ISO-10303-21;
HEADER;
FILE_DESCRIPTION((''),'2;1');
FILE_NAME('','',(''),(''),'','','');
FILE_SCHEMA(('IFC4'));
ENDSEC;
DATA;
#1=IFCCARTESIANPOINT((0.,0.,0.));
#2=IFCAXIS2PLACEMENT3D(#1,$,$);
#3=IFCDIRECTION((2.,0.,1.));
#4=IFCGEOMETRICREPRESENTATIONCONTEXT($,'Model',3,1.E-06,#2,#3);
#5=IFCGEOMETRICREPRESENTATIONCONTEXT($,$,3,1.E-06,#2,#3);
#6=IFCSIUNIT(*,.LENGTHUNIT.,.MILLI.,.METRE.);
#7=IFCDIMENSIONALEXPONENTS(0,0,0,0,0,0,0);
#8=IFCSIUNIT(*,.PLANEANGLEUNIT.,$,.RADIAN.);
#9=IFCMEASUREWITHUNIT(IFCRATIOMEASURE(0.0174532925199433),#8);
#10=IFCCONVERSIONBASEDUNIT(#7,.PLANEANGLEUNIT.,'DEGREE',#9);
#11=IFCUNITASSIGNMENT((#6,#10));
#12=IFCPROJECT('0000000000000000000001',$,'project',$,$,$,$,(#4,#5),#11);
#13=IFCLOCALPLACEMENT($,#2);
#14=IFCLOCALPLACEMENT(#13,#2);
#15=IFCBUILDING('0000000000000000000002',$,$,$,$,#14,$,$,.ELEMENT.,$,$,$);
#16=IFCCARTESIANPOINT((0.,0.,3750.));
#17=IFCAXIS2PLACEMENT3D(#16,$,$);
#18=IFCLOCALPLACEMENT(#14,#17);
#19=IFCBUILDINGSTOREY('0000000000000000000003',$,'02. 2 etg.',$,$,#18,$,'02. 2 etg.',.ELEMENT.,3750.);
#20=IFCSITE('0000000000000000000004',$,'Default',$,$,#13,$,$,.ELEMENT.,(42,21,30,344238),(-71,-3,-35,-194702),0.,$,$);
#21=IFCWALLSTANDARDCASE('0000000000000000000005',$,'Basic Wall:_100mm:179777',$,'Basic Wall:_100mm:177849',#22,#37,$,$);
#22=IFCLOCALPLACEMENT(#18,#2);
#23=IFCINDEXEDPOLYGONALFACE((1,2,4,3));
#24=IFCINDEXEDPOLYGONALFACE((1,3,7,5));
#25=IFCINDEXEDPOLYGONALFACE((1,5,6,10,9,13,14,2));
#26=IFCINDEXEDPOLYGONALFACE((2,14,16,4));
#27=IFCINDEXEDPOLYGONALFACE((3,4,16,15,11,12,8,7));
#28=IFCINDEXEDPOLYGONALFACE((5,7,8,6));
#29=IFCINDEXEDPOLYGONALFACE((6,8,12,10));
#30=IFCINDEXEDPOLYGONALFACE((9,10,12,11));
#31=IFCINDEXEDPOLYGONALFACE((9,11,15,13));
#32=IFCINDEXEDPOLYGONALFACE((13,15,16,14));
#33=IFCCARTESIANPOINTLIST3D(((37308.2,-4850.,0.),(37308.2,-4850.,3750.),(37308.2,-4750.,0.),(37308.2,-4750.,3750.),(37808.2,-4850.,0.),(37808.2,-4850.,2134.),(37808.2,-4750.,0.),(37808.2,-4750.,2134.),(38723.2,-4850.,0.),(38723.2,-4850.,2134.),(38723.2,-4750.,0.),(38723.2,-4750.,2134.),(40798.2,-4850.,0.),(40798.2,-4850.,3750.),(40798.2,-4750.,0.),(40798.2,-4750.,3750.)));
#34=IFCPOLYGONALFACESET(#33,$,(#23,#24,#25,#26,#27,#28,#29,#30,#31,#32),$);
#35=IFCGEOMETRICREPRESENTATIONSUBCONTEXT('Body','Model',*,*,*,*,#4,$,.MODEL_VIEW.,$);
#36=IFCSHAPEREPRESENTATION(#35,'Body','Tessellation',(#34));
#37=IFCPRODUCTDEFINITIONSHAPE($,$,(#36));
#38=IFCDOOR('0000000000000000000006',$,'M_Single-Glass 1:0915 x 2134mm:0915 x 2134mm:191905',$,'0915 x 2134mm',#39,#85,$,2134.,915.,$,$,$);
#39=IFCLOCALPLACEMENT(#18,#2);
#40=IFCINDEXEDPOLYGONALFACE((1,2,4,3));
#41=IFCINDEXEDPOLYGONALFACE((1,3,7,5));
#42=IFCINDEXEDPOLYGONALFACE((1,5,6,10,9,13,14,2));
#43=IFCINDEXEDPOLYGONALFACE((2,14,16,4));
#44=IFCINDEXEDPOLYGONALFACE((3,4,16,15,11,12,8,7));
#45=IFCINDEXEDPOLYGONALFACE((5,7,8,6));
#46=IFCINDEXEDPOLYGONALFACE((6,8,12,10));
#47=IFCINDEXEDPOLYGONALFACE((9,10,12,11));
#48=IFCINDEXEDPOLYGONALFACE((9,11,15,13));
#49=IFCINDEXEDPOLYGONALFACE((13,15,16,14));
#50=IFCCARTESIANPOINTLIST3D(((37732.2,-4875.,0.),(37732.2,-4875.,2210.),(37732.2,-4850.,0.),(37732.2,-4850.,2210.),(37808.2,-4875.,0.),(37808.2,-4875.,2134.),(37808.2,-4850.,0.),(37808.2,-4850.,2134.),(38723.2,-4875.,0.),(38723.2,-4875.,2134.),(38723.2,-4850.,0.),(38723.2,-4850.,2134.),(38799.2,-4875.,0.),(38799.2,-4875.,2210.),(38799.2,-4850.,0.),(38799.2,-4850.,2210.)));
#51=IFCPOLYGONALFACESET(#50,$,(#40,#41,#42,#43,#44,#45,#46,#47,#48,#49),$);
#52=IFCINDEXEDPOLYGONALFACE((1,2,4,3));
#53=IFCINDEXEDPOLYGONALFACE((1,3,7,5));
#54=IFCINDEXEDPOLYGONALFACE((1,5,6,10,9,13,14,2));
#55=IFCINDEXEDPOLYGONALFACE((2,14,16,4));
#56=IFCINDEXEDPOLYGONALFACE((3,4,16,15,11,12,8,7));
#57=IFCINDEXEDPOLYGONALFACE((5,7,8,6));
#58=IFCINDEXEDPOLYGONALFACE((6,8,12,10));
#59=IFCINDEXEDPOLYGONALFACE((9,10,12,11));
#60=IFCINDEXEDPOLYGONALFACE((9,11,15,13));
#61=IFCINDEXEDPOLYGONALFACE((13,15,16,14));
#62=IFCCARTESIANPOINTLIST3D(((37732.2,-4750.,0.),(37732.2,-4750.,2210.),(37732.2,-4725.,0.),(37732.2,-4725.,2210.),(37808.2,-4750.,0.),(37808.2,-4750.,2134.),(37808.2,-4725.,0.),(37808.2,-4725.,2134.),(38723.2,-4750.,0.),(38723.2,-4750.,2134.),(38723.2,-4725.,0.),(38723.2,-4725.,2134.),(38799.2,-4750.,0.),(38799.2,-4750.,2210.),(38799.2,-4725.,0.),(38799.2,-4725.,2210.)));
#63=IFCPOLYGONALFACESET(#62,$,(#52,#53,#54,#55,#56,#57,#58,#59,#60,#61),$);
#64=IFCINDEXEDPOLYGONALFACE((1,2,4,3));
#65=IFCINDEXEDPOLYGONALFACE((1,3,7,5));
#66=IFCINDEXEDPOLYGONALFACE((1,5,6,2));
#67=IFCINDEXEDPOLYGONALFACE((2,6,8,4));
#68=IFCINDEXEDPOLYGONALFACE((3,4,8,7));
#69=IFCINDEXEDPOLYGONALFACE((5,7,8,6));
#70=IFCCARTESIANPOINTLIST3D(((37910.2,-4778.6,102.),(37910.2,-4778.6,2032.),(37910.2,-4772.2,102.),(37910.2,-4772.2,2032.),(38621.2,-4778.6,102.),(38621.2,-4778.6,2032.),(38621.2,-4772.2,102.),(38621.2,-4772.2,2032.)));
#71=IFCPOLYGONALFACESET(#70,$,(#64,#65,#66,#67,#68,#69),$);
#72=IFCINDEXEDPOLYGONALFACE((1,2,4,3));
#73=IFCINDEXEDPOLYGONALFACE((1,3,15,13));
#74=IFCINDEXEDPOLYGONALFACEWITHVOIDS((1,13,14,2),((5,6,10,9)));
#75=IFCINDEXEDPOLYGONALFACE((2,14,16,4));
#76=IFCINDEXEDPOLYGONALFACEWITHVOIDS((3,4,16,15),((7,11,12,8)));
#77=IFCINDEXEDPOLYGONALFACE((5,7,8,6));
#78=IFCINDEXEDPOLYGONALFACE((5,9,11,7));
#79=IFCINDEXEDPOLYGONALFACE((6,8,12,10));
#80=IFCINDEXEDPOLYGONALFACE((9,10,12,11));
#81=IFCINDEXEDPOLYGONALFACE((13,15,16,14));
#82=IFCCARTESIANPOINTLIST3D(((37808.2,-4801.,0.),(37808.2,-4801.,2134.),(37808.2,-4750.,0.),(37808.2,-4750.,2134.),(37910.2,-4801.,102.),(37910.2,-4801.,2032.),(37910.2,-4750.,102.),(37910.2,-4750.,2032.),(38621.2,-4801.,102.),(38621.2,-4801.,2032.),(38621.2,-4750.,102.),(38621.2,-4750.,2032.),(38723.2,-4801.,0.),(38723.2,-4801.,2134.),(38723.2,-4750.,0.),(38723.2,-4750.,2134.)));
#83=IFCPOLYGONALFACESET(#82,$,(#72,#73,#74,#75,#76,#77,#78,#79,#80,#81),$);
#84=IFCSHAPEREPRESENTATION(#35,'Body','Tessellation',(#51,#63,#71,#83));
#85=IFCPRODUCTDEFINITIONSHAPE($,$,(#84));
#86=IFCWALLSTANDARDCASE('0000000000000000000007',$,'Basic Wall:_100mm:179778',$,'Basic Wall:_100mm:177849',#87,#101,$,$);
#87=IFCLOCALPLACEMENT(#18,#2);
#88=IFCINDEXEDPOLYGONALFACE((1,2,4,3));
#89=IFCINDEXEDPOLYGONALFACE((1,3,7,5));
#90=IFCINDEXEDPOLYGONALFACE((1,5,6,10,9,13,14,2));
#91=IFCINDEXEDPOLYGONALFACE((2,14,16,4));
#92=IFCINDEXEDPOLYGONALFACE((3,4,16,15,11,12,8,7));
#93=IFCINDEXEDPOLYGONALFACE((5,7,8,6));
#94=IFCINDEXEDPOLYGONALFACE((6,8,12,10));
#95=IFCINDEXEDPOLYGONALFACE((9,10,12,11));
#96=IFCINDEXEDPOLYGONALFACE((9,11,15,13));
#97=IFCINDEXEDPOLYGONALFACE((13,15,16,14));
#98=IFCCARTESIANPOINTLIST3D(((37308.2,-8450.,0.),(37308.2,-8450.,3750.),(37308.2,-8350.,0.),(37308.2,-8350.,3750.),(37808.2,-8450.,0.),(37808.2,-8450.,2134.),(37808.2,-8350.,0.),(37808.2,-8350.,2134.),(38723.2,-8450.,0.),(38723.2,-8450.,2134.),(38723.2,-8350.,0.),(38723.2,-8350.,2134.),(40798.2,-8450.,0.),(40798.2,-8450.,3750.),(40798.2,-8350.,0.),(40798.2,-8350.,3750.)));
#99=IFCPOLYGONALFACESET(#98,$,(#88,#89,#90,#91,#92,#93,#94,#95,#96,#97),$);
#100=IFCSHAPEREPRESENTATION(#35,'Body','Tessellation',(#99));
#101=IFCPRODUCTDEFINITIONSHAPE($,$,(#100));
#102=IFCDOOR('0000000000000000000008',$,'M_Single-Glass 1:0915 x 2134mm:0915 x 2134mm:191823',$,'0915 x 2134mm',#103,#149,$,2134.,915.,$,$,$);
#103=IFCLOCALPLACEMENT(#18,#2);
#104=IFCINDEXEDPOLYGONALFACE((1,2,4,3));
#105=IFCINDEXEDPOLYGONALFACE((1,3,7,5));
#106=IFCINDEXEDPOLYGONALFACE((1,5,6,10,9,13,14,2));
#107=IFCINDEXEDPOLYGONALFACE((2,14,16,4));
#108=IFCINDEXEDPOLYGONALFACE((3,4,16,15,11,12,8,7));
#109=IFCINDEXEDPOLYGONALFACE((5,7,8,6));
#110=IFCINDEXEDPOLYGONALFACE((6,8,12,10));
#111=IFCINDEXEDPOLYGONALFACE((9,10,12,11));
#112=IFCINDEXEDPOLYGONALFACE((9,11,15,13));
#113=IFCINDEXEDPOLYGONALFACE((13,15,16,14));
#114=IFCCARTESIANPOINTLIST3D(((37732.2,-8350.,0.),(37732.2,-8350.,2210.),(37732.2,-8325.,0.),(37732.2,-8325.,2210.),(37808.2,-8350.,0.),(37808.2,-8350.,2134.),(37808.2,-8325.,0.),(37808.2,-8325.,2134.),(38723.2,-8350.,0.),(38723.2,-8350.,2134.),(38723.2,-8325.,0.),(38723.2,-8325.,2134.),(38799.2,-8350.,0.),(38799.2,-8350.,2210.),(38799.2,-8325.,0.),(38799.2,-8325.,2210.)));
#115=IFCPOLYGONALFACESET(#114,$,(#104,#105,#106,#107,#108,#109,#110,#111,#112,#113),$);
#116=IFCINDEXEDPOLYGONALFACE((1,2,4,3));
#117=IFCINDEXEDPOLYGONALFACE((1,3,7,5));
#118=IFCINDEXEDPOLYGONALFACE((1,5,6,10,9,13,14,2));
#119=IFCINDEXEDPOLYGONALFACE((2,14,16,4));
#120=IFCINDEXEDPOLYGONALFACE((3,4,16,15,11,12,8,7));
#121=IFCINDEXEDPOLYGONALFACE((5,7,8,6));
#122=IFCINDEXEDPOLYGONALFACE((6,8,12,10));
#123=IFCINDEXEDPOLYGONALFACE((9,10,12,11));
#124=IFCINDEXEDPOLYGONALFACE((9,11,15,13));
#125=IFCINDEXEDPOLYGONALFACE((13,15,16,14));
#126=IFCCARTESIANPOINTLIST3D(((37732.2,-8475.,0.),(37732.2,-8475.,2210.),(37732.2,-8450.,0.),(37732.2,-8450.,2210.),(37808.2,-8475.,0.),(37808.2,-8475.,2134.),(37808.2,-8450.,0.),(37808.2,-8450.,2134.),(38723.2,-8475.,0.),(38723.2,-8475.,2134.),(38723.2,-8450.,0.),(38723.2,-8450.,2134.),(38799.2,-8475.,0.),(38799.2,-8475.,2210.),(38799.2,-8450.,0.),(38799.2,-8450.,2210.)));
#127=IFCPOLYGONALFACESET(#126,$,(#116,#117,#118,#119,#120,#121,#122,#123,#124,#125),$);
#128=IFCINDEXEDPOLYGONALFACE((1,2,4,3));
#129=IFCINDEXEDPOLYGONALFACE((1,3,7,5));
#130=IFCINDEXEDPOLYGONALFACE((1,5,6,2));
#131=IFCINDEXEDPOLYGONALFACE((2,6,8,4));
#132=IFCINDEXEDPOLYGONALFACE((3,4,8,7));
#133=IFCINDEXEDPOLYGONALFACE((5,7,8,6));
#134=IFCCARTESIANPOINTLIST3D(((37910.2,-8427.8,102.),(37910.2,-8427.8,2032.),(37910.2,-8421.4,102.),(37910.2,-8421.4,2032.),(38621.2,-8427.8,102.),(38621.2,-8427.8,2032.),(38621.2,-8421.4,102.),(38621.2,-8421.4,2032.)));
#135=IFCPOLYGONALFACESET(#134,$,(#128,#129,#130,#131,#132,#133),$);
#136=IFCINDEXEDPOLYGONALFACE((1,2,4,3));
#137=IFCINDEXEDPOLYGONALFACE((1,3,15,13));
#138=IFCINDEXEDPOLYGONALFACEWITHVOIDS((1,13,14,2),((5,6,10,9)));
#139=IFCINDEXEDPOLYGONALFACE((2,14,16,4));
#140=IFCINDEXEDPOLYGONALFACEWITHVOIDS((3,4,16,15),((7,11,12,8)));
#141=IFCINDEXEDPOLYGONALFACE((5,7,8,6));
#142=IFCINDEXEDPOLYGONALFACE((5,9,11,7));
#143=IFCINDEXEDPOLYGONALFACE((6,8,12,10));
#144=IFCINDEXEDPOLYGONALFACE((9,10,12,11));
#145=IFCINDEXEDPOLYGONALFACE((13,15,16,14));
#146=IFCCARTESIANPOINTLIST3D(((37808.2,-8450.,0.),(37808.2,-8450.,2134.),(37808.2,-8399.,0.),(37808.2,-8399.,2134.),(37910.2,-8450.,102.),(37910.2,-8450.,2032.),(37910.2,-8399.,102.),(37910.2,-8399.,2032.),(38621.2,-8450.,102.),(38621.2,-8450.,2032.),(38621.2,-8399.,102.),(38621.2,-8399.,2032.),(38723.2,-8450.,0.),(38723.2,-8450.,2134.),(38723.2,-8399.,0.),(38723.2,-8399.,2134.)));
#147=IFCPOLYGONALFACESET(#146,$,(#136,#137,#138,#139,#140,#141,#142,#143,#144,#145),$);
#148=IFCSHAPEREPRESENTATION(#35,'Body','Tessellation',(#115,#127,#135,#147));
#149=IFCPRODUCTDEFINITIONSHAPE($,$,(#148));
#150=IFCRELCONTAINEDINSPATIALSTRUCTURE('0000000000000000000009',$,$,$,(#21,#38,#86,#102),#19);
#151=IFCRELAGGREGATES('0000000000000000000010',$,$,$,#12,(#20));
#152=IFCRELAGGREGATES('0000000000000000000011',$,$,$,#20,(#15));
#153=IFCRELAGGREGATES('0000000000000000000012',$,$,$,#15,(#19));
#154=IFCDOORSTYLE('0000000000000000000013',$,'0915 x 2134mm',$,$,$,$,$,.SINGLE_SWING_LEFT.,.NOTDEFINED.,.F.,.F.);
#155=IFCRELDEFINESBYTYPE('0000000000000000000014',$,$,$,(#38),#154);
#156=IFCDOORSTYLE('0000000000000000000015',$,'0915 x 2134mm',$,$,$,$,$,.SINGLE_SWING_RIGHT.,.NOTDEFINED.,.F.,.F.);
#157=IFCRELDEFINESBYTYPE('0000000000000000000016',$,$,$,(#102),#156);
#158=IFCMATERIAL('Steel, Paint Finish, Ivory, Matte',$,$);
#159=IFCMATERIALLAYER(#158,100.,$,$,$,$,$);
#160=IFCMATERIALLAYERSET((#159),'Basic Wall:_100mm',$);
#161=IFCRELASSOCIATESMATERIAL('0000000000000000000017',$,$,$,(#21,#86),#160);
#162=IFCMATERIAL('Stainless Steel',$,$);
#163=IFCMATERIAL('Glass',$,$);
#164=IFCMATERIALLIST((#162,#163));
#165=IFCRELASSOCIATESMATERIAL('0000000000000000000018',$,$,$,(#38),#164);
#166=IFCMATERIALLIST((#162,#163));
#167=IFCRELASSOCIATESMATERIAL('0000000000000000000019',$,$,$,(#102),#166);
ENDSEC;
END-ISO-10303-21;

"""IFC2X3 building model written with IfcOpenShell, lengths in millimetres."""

from ifc_helpers import new_model, entity, si_unit, converted_unit, direction, frame, frame_2d, origin, origin_2d_with_axis, place, context, subcontext, project, spatial, polyline, rectangle, outline, extrude, source, transform, mapped, material, material_list, layer, layer_set, layer_usage, type_object, type_shapes, element, fill, save


model = new_model("IFC2X3")

# Units and contexts
model_context = context("Model", 3, precision=1e-06, world=origin(), true_north=direction((2.0, 0.0, 1.0)))
context_of_model = context(None, 3, precision=1e-06, world=origin(), true_north=direction((2.0, 0.0, 1.0)))
body_context = subcontext(model_context, "Body", "Model", "MODEL_VIEW")
ifc_project = project(units=[si_unit("LENGTHUNIT", "METRE", prefix="MILLI"), converted_unit("PLANEANGLEUNIT", "DEGREE", entity("IfcRatioMeasure", 0.0174532925199433), si_unit("PLANEANGLEUNIT", "RADIAN"), dimensions=[0, 0, 0, 0, 0, 0, 0])], contexts=[model_context, context_of_model])

# Site, building, storey
site_placement = place(None, origin())
site = spatial("IfcSite", under=ifc_project, at=site_placement, Name="Default", CompositionType="ELEMENT", RefLatitude=(42, 21, 30, 344238), RefLongitude=(-71, -3, -35, -194702), RefElevation=0.0)
building_placement = place(site_placement, origin())
building = spatial("IfcBuilding", under=site, at=building_placement, CompositionType="ELEMENT")
storey_placement = place(building_placement, frame((0.0, 0.0, 3750.0)))
storey = spatial("IfcBuildingStorey", under=building, at=storey_placement, Name="02. 2 etg.", LongName="02. 2 etg.", CompositionType="ELEMENT", Elevation=3750.0)

# Shared definitions
ifc_material_1 = material(Name="Glass")

# Walls, openings, doors
ifc_material_2 = material(Name="Steel, Paint Finish, Ivory, Matte")
ifc_layer = layer(ifc_material_2, 100.0)
ifc_layer_set = layer_set([ifc_layer], Name="Basic Wall:_100mm")
ifc_layer_usage_1 = layer_usage(ifc_layer_set, "AXIS2", "POSITIVE", -50.0)
wall_1_placement = place(storey_placement, frame((37308.2, -4800.0, 0.0)))
wall_1 = element("IfcWallStandardCase", 1, at=wall_1_placement, inside=storey, material=ifc_layer_usage_1, Name="Basic Wall:_100mm:179777", ObjectType="Basic Wall:_100mm:177849", context=body_context, shape_type="SweptSolid", body=[
    extrude(rectangle(XDim=3490.0, YDim=100.0, at=frame_2d((1745.0, 0.0), x_axis=(-1.0, 0.0))), origin(), (0.0, 0.0, 1.0), 3750.0),
])
opening_1_placement = place(wall_1_placement, frame((500.0, -50.0, 0.0)))
opening_1 = element("IfcOpeningElement", 2, at=opening_1_placement, cuts=wall_1, ObjectType="Opening", context=body_context, shape_type="SweptSolid", body=[
    extrude(rectangle(XDim=915.0, YDim=2134.0, at=frame_2d((1067.0, 457.5), x_axis=(0.0, -1.0))), frame((0.0, 0.0, 0.0), z_axis=(0.0, 1.0, 0.0), x_axis=(0.0, 0.0, 1.0)), (0.0, 0.0, 1.0), 100.0),
])
ifc_material_3 = material(Name="Stainless Steel")
ifc_material_list_1 = material_list([ifc_material_3, ifc_material_1])
door_style_1 = type_object("IfcDoorStyle", Name="0915 x 2134mm", ConstructionType="NOTDEFINED", OperationType="SINGLE_SWING_LEFT", ParameterTakesPrecedence=False, Sizeable=False)
shared_shape_1 = source(origin(), body_context, "Body", "SweptSolid", [
    extrude(outline(polyline([(-457.5, -1048.0), (-457.5, 1086.0), (-533.5, 1086.0), (-533.5, -1124.0), (533.5, -1124.0), (533.5, 1086.0), (457.5, 1086.0), (457.5, -1048.0), (-457.5, -1048.0)])), frame((457.5, 0.0, 1086.0), z_axis=(0.0, 1.0, 0.0), x_axis=(1.0, 0.0, 0.0)), (0.0, 0.0, -1.0), 25.0),
    extrude(outline(polyline([(-457.5, -1048.0), (-457.5, 1086.0), (-533.5, 1086.0), (-533.5, -1124.0), (533.5, -1124.0), (533.5, 1086.0), (457.5, 1086.0), (457.5, -1048.0), (-457.5, -1048.0)])), frame((457.5, 125.0, 1086.0), z_axis=(0.0, 1.0, 0.0), x_axis=(1.0, 0.0, 0.0)), (0.0, 0.0, -1.0), 25.0),
    extrude(rectangle(XDim=711.0, YDim=6.3, at=origin_2d_with_axis()), frame((457.5, 74.6, 102.0)), (0.0, 0.0, 1.0), 1930.0),
    extrude(outline(polyline([(-1067.0, -457.5), (1067.0, -457.5), (1067.0, 457.5), (-1067.0, 457.5), (-1067.0, -457.5)]), holes=[polyline([(-965.0, 355.5), (965.0, 355.5), (965.0, -355.5), (-965.0, -355.5), (-965.0, 355.5)])]), frame((457.5, 100.0, 1067.0), z_axis=(0.0, -1.0, 0.0), x_axis=(0.0, 0.0, -1.0)), (0.0, 0.0, 1.0), 51.0),
])
type_shapes(door_style_1, [shared_shape_1])
door_1_placement = place(opening_1_placement, origin())
door_1 = element("IfcDoor", 3, at=door_1_placement, inside=storey, type_object=door_style_1, material=ifc_material_list_1, Name="M_Single-Glass 1:0915 x 2134mm:0915 x 2134mm:191905", ObjectType="0915 x 2134mm", OverallHeight=2134.0, OverallWidth=915.0, context=body_context, shape_type="MappedRepresentation", body=[
    mapped(shared_shape_1, transform((0.0, 0.0, 0.0), scale=1.0)),
])
fill(opening_1, door_1)
ifc_layer_usage_2 = layer_usage(ifc_layer_set, "AXIS2", "POSITIVE", -50.0)
wall_2_placement = place(storey_placement, frame((37308.2, -8400.0, 0.0)))
wall_2 = element("IfcWallStandardCase", 4, at=wall_2_placement, inside=storey, material=ifc_layer_usage_2, Name="Basic Wall:_100mm:179778", ObjectType="Basic Wall:_100mm:177849", context=body_context, shape_type="SweptSolid", body=[
    extrude(rectangle(XDim=3490.0, YDim=100.0, at=frame_2d((1745.0, 0.0), x_axis=(-1.0, 0.0))), origin(), (0.0, 0.0, 1.0), 3750.0),
])
opening_2_placement = place(wall_2_placement, frame((1415.0, 50.0, 0.0)))
opening_2 = element("IfcOpeningElement", 5, at=opening_2_placement, cuts=wall_2, ObjectType="Opening", context=body_context, shape_type="SweptSolid", body=[
    extrude(rectangle(XDim=915.0, YDim=2134.0, at=frame_2d((1067.0, 457.5), x_axis=(0.0, 1.0))), frame((0.0, 0.0, 0.0), z_axis=(0.0, -1.0, 0.0), x_axis=(0.0, 0.0, 1.0)), (0.0, 0.0, 1.0), 100.0),
])
ifc_material_list_2 = material_list([ifc_material_3, ifc_material_1])
door_style_2 = type_object("IfcDoorStyle", Name="0915 x 2134mm", ConstructionType="NOTDEFINED", OperationType="SINGLE_SWING_RIGHT", ParameterTakesPrecedence=False, Sizeable=False)
shared_shape_2 = source(origin(), body_context, "Body", "SweptSolid", [
    extrude(outline(polyline([(-457.5, -1048.0), (-457.5, 1086.0), (-533.5, 1086.0), (-533.5, -1124.0), (533.5, -1124.0), (533.5, 1086.0), (457.5, 1086.0), (457.5, -1048.0), (-457.5, -1048.0)])), frame((457.5, -25.0, 1086.0), z_axis=(0.0, -1.0, 0.0), x_axis=(-1.0, 0.0, 0.0)), (0.0, 0.0, -1.0), 25.0),
    extrude(outline(polyline([(-457.5, -1048.0), (-457.5, 1086.0), (-533.5, 1086.0), (-533.5, -1124.0), (533.5, -1124.0), (533.5, 1086.0), (457.5, 1086.0), (457.5, -1048.0), (-457.5, -1048.0)])), frame((457.5, 100.0, 1086.0), z_axis=(0.0, -1.0, 0.0), x_axis=(-1.0, 0.0, 0.0)), (0.0, 0.0, -1.0), 25.0),
    extrude(rectangle(XDim=6.3, YDim=711.0, at=frame_2d((0.0, 0.0), x_axis=(1.0, 0.0))), frame((457.5, 74.6, 102.0), z_axis=(0.0, 0.0, 1.0), x_axis=(0.0, 1.0, 0.0)), (0.0, 0.0, 1.0), 1930.0),
    extrude(outline(polyline([(-1067.0, -457.5), (1067.0, -457.5), (1067.0, 457.5), (-1067.0, 457.5), (-1067.0, -457.5)]), holes=[polyline([(-965.0, 355.5), (965.0, 355.5), (965.0, -355.5), (-965.0, -355.5), (-965.0, 355.5)])]), frame((457.5, 49.0, 1067.0), z_axis=(0.0, 1.0, 0.0), x_axis=(0.0, 0.0, -1.0)), (0.0, 0.0, 1.0), 51.0),
])
type_shapes(door_style_2, [shared_shape_2])
door_2_placement = place(opening_2_placement, frame((0.0, 0.0, 0.0), z_axis=(0.0, 0.0, 1.0), x_axis=(-1.0, 0.0, 0.0)))
door_2 = element("IfcDoor", 6, at=door_2_placement, inside=storey, type_object=door_style_2, material=ifc_material_list_2, Name="M_Single-Glass 1:0915 x 2134mm:0915 x 2134mm:191823", ObjectType="0915 x 2134mm", OverallHeight=2134.0, OverallWidth=915.0, context=body_context, shape_type="MappedRepresentation", body=[
    mapped(shared_shape_2, transform((0.0, 0.0, 0.0), scale=1.0)),
])
fill(opening_2, door_2)

save(model, "model.ifc")
